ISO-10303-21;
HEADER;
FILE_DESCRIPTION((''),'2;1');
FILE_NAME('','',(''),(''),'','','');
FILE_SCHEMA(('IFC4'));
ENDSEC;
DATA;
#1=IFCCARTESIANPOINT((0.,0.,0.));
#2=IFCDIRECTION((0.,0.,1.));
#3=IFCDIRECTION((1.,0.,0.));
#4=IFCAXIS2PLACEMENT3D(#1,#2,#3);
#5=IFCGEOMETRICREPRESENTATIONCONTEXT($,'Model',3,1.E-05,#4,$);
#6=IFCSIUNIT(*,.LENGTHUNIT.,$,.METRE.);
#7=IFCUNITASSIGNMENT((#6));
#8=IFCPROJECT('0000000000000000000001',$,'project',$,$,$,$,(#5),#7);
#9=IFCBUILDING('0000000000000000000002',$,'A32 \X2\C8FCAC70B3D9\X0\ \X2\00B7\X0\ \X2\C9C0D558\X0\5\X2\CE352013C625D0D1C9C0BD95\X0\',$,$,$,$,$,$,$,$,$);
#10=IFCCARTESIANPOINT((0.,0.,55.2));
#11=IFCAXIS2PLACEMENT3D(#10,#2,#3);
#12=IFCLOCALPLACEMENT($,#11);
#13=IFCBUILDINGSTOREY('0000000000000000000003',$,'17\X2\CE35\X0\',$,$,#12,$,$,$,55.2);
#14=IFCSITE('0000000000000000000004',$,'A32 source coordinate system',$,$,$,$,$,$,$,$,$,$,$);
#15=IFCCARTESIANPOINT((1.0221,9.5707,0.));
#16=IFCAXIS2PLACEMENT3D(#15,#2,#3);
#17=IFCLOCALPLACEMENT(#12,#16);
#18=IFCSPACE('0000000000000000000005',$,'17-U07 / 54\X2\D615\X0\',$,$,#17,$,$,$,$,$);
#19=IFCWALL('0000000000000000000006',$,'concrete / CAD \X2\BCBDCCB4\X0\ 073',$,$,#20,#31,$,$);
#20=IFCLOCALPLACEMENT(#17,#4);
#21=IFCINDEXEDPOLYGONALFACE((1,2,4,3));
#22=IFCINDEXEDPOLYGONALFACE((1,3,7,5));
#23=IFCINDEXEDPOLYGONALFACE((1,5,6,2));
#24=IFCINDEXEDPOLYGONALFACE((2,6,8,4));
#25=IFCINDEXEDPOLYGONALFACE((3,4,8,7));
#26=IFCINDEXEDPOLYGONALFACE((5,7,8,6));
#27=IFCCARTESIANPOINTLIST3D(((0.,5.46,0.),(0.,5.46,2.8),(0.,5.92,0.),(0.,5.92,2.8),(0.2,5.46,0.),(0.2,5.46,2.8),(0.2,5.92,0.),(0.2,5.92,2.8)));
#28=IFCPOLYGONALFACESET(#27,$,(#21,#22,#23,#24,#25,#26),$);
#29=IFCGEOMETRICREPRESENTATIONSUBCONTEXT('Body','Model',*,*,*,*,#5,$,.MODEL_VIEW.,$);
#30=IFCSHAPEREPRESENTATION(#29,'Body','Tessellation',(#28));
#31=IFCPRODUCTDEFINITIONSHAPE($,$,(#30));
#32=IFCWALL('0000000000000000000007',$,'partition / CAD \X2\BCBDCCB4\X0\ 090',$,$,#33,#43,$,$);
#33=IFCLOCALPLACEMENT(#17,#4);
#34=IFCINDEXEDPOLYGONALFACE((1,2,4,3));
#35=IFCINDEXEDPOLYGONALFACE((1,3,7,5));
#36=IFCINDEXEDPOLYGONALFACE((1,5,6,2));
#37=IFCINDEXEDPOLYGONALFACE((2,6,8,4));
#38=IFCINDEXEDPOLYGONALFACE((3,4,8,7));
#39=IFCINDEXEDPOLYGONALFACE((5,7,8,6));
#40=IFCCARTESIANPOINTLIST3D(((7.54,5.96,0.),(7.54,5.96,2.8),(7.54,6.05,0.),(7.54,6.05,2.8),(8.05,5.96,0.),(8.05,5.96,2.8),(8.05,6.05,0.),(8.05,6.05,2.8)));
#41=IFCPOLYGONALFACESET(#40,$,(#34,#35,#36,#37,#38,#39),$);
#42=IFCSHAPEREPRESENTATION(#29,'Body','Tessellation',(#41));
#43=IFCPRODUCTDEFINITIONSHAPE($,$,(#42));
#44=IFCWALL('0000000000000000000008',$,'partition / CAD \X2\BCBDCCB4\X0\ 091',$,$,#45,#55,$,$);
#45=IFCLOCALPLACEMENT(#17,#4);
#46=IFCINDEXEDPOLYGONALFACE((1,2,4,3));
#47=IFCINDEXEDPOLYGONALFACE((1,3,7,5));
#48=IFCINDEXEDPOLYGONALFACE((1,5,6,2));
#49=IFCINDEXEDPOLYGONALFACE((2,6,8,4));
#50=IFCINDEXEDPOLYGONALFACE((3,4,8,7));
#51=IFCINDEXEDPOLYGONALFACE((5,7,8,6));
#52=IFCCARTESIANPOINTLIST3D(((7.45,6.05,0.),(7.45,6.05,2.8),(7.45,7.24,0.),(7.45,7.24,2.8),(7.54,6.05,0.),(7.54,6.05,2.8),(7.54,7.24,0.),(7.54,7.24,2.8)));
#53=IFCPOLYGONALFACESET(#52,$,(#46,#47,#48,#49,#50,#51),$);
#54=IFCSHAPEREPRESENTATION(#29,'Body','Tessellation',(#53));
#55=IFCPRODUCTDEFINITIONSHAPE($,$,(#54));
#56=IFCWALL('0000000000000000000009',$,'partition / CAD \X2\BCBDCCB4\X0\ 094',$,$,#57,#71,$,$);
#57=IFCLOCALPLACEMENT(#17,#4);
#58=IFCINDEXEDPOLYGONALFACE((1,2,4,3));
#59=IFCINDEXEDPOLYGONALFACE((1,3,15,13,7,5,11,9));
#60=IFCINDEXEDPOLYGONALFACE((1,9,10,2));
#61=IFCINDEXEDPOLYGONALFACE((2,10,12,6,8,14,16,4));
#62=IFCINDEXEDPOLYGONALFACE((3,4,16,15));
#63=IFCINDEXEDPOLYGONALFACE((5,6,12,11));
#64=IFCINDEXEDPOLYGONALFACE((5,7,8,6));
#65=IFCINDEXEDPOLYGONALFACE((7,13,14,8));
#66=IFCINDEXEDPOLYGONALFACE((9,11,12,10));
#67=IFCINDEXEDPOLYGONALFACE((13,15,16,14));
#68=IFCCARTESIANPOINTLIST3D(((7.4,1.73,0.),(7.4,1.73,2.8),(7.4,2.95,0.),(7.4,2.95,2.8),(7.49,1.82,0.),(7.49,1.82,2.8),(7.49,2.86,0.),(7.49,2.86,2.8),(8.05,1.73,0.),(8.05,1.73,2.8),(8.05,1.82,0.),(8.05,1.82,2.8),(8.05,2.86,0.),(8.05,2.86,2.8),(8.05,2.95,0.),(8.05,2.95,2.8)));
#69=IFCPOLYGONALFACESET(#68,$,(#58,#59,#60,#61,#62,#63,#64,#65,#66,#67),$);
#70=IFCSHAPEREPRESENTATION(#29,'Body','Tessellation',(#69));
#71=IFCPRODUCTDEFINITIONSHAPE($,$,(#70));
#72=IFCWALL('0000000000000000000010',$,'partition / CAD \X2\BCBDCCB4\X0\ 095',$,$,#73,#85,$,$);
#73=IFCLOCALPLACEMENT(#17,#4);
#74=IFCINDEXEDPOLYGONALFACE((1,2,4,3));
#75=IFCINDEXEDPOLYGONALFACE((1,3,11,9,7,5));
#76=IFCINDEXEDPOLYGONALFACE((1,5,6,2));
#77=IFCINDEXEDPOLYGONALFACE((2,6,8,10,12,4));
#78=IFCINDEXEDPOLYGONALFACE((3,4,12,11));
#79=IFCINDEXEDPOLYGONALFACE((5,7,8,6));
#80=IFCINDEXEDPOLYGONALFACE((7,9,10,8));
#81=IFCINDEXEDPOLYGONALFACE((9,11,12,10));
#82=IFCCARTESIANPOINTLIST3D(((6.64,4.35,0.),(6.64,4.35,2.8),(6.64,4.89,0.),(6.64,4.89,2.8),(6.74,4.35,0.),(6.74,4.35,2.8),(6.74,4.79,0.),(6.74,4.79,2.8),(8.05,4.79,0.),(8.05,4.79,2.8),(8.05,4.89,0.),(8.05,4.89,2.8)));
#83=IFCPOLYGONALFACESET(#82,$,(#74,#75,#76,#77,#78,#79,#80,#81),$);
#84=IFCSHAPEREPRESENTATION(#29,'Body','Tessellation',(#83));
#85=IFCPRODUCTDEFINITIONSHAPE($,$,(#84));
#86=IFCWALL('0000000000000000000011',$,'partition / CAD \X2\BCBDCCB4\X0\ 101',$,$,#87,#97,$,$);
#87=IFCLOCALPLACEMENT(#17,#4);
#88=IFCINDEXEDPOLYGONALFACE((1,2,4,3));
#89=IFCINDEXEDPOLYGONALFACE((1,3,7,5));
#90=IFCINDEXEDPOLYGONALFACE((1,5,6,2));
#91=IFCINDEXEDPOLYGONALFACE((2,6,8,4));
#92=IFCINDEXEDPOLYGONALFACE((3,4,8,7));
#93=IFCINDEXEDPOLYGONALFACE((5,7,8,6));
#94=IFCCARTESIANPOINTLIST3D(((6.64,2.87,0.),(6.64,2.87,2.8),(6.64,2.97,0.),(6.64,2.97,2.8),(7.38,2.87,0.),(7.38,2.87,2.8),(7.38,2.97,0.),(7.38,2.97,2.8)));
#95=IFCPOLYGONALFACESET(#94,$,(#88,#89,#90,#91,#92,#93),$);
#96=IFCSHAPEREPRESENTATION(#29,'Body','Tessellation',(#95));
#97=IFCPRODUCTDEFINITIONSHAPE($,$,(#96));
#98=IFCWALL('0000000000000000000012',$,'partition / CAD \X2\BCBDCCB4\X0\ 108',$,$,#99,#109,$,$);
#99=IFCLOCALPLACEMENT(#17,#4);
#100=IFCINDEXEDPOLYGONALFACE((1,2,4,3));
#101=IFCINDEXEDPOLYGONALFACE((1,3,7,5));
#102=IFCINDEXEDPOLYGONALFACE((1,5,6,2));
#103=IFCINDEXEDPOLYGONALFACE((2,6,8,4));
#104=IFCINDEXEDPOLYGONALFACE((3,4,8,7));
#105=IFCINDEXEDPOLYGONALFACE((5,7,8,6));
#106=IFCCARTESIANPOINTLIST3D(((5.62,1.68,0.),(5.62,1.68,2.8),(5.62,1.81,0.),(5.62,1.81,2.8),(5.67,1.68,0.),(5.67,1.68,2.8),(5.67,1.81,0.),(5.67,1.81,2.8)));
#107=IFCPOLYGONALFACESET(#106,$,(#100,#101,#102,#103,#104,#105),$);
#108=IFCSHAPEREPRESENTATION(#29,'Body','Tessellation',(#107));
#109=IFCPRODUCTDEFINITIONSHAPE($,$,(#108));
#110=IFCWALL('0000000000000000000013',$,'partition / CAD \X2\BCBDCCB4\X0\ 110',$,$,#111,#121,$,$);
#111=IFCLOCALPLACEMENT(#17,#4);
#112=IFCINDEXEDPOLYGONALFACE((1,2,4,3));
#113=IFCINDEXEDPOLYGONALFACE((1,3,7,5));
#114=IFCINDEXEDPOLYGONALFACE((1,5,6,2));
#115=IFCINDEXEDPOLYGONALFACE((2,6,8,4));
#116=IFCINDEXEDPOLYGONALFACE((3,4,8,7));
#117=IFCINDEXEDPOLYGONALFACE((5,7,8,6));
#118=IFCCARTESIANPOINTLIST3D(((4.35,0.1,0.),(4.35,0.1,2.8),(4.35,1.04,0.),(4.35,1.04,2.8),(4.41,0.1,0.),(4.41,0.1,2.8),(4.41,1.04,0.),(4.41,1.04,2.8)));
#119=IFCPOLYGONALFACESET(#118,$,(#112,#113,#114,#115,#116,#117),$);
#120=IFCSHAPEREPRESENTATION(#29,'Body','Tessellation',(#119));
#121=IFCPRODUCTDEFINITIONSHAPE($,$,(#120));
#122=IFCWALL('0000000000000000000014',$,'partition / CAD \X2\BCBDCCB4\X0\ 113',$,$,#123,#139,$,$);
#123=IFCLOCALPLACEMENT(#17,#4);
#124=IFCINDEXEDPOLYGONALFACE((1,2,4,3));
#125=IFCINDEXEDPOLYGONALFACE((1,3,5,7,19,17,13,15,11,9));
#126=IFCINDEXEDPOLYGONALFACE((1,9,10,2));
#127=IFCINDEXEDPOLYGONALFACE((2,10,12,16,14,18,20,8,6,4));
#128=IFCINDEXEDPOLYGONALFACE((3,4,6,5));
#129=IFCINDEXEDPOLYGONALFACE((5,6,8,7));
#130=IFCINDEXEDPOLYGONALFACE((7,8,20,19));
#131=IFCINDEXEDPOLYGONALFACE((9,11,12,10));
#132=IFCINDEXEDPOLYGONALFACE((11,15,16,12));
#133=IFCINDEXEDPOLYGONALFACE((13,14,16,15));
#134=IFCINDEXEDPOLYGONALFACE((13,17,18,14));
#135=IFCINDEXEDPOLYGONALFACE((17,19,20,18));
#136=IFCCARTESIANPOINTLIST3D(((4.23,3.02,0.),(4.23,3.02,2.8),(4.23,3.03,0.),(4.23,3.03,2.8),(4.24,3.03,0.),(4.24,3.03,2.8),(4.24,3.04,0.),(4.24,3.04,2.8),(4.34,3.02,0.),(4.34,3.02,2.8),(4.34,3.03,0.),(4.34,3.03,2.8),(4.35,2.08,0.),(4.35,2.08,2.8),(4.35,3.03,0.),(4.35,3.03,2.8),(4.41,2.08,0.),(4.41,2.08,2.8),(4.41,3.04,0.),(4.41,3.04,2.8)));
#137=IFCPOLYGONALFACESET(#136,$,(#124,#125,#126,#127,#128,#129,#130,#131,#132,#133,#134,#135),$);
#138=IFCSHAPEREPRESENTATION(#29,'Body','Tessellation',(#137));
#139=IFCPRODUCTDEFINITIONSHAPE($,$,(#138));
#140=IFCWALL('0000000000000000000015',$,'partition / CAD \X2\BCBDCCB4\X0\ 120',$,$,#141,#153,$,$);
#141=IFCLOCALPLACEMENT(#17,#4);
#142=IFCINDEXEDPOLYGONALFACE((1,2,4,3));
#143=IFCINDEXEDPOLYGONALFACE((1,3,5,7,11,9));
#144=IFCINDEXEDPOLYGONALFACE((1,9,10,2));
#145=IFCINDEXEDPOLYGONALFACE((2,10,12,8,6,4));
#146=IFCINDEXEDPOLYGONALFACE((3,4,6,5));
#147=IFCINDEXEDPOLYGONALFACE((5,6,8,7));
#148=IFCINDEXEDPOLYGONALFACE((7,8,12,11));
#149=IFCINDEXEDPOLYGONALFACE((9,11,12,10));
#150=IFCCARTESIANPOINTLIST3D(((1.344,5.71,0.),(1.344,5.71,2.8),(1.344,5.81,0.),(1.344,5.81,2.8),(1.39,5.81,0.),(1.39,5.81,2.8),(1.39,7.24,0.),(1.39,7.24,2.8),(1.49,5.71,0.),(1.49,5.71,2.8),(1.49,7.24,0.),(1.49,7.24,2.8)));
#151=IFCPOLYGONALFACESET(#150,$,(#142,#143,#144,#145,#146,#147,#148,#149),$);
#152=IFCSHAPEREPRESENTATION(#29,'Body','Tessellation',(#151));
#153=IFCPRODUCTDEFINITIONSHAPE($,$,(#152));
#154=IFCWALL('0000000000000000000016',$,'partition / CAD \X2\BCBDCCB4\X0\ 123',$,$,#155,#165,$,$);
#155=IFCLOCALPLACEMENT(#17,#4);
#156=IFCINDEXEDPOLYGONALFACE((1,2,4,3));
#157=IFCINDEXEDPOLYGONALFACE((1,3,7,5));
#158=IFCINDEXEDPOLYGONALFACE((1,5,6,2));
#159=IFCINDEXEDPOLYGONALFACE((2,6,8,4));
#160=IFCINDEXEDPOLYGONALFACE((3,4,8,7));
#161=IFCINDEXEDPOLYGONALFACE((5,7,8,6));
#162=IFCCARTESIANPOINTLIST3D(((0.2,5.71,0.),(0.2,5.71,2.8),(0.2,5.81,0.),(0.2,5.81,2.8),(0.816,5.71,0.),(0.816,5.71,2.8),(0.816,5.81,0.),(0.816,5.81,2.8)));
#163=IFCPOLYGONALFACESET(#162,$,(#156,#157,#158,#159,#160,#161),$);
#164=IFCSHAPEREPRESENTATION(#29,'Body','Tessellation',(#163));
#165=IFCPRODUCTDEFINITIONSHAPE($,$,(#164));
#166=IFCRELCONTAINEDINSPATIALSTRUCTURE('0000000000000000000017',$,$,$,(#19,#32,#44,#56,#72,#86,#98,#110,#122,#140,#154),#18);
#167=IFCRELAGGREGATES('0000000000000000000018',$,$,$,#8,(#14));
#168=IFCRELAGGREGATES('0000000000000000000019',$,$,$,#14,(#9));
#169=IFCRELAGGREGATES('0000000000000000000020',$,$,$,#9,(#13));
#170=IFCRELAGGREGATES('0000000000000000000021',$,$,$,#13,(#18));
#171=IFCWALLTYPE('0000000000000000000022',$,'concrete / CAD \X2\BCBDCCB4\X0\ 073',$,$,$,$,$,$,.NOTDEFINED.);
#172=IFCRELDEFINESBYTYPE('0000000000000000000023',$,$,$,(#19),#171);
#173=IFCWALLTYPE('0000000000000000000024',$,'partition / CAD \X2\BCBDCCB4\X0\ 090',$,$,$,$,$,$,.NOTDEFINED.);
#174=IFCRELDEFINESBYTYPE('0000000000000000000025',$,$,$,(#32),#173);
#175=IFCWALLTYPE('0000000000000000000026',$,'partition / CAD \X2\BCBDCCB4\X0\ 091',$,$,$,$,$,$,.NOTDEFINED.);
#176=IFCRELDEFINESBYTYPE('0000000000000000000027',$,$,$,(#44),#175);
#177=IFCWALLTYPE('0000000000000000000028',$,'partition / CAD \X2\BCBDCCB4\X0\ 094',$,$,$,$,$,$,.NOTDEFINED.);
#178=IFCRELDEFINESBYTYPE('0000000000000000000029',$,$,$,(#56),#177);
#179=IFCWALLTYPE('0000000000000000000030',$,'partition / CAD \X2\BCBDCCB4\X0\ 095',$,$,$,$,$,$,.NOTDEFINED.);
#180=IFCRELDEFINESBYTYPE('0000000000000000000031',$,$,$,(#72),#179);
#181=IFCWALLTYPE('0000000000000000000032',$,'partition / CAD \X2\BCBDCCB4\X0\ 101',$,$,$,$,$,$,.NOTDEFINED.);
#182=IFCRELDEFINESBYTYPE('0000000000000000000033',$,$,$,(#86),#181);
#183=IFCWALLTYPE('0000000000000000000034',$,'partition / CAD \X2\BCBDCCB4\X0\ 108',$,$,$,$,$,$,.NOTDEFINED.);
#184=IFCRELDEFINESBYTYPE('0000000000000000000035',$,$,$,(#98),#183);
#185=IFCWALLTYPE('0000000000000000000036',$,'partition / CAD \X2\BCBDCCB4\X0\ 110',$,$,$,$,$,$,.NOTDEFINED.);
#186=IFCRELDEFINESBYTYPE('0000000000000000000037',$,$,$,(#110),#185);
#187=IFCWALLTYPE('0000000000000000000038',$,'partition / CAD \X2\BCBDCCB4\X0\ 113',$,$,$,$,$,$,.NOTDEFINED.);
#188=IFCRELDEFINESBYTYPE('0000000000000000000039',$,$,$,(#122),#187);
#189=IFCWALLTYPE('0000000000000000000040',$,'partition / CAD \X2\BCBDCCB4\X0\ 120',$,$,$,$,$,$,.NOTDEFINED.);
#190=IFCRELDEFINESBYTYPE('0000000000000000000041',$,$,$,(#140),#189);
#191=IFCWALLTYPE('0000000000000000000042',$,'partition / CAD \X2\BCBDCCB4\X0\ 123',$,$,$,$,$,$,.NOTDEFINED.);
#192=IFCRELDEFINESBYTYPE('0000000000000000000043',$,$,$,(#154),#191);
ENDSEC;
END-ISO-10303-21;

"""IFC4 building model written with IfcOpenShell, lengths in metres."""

from ifc_helpers import new_model, si_unit, frame, origin, origin_with_axes, place, context, subcontext, project, spatial, polyline, outline, extrude, source, transform, mapped, type_object, type_shapes, element, save


model = new_model("IFC4")

# Units and contexts
model_context = context("Model", 3, precision=1e-05, world=origin_with_axes())
body_context = subcontext(model_context, "Body", "Model", "MODEL_VIEW")
ifc_project = project(units=[si_unit("LENGTHUNIT", "METRE")], contexts=[model_context])

# Site, building, storey, space
site = spatial("IfcSite", under=ifc_project, Name="A32 source coordinate system")
building = spatial("IfcBuilding", under=site, Name="A32 주거동 · 지하5층–옥탑지붕")
storey_placement = place(None, frame((0.0, 0.0, 55.2), z_axis=(0.0, 0.0, 1.0), x_axis=(1.0, 0.0, 0.0)))
storey = spatial("IfcBuildingStorey", under=building, at=storey_placement, Name="17층", Elevation=55.2)
space_1_placement = place(storey_placement, frame((1.0221, 9.5707, 0.0), z_axis=(0.0, 0.0, 1.0), x_axis=(1.0, 0.0, 0.0)))
space_1 = spatial("IfcSpace", under=storey, at=space_1_placement, Name="17-U07 / 54형")

# Walls
wall_type_1 = type_object("IfcWallType", Name="concrete / CAD 벽체 073", PredefinedType="NOTDEFINED")
shared_shape_1 = source(origin(), body_context, "Body", "SweptSolid", [
    extrude(outline(polyline([(0.2, 5.92), (0.2, 5.46), (0.0, 5.46), (0.0, 5.92), (0.2, 5.92)])), origin(), (0.0, 0.0, 1.0), 2.8),
])
type_shapes(wall_type_1, [shared_shape_1])
wall_1_placement = place(space_1_placement, origin_with_axes())
element("IfcWall", 1, at=wall_1_placement, inside=space_1, type_object=wall_type_1, Name="concrete / CAD 벽체 073", context=body_context, shape_type="MappedRepresentation", body=[
    mapped(shared_shape_1, transform((0.0, 0.0, 0.0), scale=1.0)),
])
wall_type_2 = type_object("IfcWallType", Name="partition / CAD 벽체 090", PredefinedType="NOTDEFINED")
shared_shape_2 = source(origin(), body_context, "Body", "SweptSolid", [
    extrude(outline(polyline([(7.54, 5.96), (7.54, 6.05), (8.05, 6.05), (8.05, 5.96), (7.54, 5.96)])), origin(), (0.0, 0.0, 1.0), 2.8),
])
type_shapes(wall_type_2, [shared_shape_2])
wall_2_placement = place(space_1_placement, origin_with_axes())
element("IfcWall", 2, at=wall_2_placement, inside=space_1, type_object=wall_type_2, Name="partition / CAD 벽체 090", context=body_context, shape_type="MappedRepresentation", body=[
    mapped(shared_shape_2, transform((0.0, 0.0, 0.0), scale=1.0)),
])
wall_type_3 = type_object("IfcWallType", Name="partition / CAD 벽체 091", PredefinedType="NOTDEFINED")
shared_shape_3 = source(origin(), body_context, "Body", "SweptSolid", [
    extrude(outline(polyline([(7.54, 6.05), (7.45, 6.05), (7.45, 7.24), (7.54, 7.24), (7.54, 6.05)])), origin(), (0.0, 0.0, 1.0), 2.8),
])
type_shapes(wall_type_3, [shared_shape_3])
wall_3_placement = place(space_1_placement, origin_with_axes())
element("IfcWall", 3, at=wall_3_placement, inside=space_1, type_object=wall_type_3, Name="partition / CAD 벽체 091", context=body_context, shape_type="MappedRepresentation", body=[
    mapped(shared_shape_3, transform((0.0, 0.0, 0.0), scale=1.0)),
])
wall_type_4 = type_object("IfcWallType", Name="partition / CAD 벽체 094", PredefinedType="NOTDEFINED")
shared_shape_4 = source(origin(), body_context, "Body", "SweptSolid", [
    extrude(outline(polyline([(8.05, 1.73), (7.4, 1.73), (7.4, 2.95), (8.05, 2.95), (8.05, 2.86), (7.49, 2.86), (7.49, 1.82), (8.05, 1.82), (8.05, 1.73)])), origin(), (0.0, 0.0, 1.0), 2.8),
])
type_shapes(wall_type_4, [shared_shape_4])
wall_4_placement = place(space_1_placement, origin_with_axes())
element("IfcWall", 4, at=wall_4_placement, inside=space_1, type_object=wall_type_4, Name="partition / CAD 벽체 094", context=body_context, shape_type="MappedRepresentation", body=[
    mapped(shared_shape_4, transform((0.0, 0.0, 0.0), scale=1.0)),
])
wall_type_5 = type_object("IfcWallType", Name="partition / CAD 벽체 095", PredefinedType="NOTDEFINED")
shared_shape_5 = source(origin(), body_context, "Body", "SweptSolid", [
    extrude(outline(polyline([(6.64, 4.89), (8.05, 4.89), (8.05, 4.79), (6.74, 4.79), (6.74, 4.35), (6.64, 4.35), (6.64, 4.89)])), origin(), (0.0, 0.0, 1.0), 2.8),
])
type_shapes(wall_type_5, [shared_shape_5])
wall_5_placement = place(space_1_placement, origin_with_axes())
element("IfcWall", 5, at=wall_5_placement, inside=space_1, type_object=wall_type_5, Name="partition / CAD 벽체 095", context=body_context, shape_type="MappedRepresentation", body=[
    mapped(shared_shape_5, transform((0.0, 0.0, 0.0), scale=1.0)),
])
wall_type_6 = type_object("IfcWallType", Name="partition / CAD 벽체 101", PredefinedType="NOTDEFINED")
shared_shape_6 = source(origin(), body_context, "Body", "SweptSolid", [
    extrude(outline(polyline([(7.38, 2.97), (7.38, 2.87), (6.64, 2.87), (6.64, 2.97), (7.38, 2.97)])), origin(), (0.0, 0.0, 1.0), 2.8),
])
type_shapes(wall_type_6, [shared_shape_6])
wall_6_placement = place(space_1_placement, origin_with_axes())
element("IfcWall", 6, at=wall_6_placement, inside=space_1, type_object=wall_type_6, Name="partition / CAD 벽체 101", context=body_context, shape_type="MappedRepresentation", body=[
    mapped(shared_shape_6, transform((0.0, 0.0, 0.0), scale=1.0)),
])
wall_type_7 = type_object("IfcWallType", Name="partition / CAD 벽체 108", PredefinedType="NOTDEFINED")
shared_shape_7 = source(origin(), body_context, "Body", "SweptSolid", [
    extrude(outline(polyline([(5.67, 1.68), (5.62, 1.68), (5.62, 1.81), (5.67, 1.81), (5.67, 1.68)])), origin(), (0.0, 0.0, 1.0), 2.8),
])
type_shapes(wall_type_7, [shared_shape_7])
wall_7_placement = place(space_1_placement, origin_with_axes())
element("IfcWall", 7, at=wall_7_placement, inside=space_1, type_object=wall_type_7, Name="partition / CAD 벽체 108", context=body_context, shape_type="MappedRepresentation", body=[
    mapped(shared_shape_7, transform((0.0, 0.0, 0.0), scale=1.0)),
])
wall_type_8 = type_object("IfcWallType", Name="partition / CAD 벽체 110", PredefinedType="NOTDEFINED")
shared_shape_8 = source(origin(), body_context, "Body", "SweptSolid", [
    extrude(outline(polyline([(4.35, 1.04), (4.41, 1.04), (4.41, 0.1), (4.35, 0.1), (4.35, 1.04)])), origin(), (0.0, 0.0, 1.0), 2.8),
])
type_shapes(wall_type_8, [shared_shape_8])
wall_8_placement = place(space_1_placement, origin_with_axes())
element("IfcWall", 8, at=wall_8_placement, inside=space_1, type_object=wall_type_8, Name="partition / CAD 벽체 110", context=body_context, shape_type="MappedRepresentation", body=[
    mapped(shared_shape_8, transform((0.0, 0.0, 0.0), scale=1.0)),
])
wall_type_9 = type_object("IfcWallType", Name="partition / CAD 벽체 113", PredefinedType="NOTDEFINED")
shared_shape_9 = source(origin(), body_context, "Body", "SweptSolid", [
    extrude(outline(polyline([(4.24, 3.04), (4.41, 3.04), (4.41, 2.08), (4.35, 2.08), (4.35, 3.03), (4.34, 3.03), (4.34, 3.02), (4.23, 3.02), (4.23, 3.03), (4.24, 3.03), (4.24, 3.04)])), origin(), (0.0, 0.0, 1.0), 2.8),
])
type_shapes(wall_type_9, [shared_shape_9])
wall_9_placement = place(space_1_placement, origin_with_axes())
element("IfcWall", 9, at=wall_9_placement, inside=space_1, type_object=wall_type_9, Name="partition / CAD 벽체 113", context=body_context, shape_type="MappedRepresentation", body=[
    mapped(shared_shape_9, transform((0.0, 0.0, 0.0), scale=1.0)),
])
wall_type_10 = type_object("IfcWallType", Name="partition / CAD 벽체 120", PredefinedType="NOTDEFINED")
shared_shape_10 = source(origin(), body_context, "Body", "SweptSolid", [
    extrude(outline(polyline([(1.39, 7.24), (1.49, 7.24), (1.49, 5.71), (1.344, 5.71), (1.344, 5.81), (1.39, 5.81), (1.39, 7.24)])), origin(), (0.0, 0.0, 1.0), 2.8),
])
type_shapes(wall_type_10, [shared_shape_10])
wall_10_placement = place(space_1_placement, origin_with_axes())
element("IfcWall", 10, at=wall_10_placement, inside=space_1, type_object=wall_type_10, Name="partition / CAD 벽체 120", context=body_context, shape_type="MappedRepresentation", body=[
    mapped(shared_shape_10, transform((0.0, 0.0, 0.0), scale=1.0)),
])
wall_type_11 = type_object("IfcWallType", Name="partition / CAD 벽체 123", PredefinedType="NOTDEFINED")
shared_shape_11 = source(origin(), body_context, "Body", "SweptSolid", [
    extrude(outline(polyline([(0.816, 5.81), (0.816, 5.71), (0.2, 5.71), (0.2, 5.81), (0.816, 5.81)])), origin(), (0.0, 0.0, 1.0), 2.8),
])
type_shapes(wall_type_11, [shared_shape_11])
wall_11_placement = place(space_1_placement, origin_with_axes())
element("IfcWall", 11, at=wall_11_placement, inside=space_1, type_object=wall_type_11, Name="partition / CAD 벽체 123", context=body_context, shape_type="MappedRepresentation", body=[
    mapped(shared_shape_11, transform((0.0, 0.0, 0.0), scale=1.0)),
])

save(model, "model.ifc")
